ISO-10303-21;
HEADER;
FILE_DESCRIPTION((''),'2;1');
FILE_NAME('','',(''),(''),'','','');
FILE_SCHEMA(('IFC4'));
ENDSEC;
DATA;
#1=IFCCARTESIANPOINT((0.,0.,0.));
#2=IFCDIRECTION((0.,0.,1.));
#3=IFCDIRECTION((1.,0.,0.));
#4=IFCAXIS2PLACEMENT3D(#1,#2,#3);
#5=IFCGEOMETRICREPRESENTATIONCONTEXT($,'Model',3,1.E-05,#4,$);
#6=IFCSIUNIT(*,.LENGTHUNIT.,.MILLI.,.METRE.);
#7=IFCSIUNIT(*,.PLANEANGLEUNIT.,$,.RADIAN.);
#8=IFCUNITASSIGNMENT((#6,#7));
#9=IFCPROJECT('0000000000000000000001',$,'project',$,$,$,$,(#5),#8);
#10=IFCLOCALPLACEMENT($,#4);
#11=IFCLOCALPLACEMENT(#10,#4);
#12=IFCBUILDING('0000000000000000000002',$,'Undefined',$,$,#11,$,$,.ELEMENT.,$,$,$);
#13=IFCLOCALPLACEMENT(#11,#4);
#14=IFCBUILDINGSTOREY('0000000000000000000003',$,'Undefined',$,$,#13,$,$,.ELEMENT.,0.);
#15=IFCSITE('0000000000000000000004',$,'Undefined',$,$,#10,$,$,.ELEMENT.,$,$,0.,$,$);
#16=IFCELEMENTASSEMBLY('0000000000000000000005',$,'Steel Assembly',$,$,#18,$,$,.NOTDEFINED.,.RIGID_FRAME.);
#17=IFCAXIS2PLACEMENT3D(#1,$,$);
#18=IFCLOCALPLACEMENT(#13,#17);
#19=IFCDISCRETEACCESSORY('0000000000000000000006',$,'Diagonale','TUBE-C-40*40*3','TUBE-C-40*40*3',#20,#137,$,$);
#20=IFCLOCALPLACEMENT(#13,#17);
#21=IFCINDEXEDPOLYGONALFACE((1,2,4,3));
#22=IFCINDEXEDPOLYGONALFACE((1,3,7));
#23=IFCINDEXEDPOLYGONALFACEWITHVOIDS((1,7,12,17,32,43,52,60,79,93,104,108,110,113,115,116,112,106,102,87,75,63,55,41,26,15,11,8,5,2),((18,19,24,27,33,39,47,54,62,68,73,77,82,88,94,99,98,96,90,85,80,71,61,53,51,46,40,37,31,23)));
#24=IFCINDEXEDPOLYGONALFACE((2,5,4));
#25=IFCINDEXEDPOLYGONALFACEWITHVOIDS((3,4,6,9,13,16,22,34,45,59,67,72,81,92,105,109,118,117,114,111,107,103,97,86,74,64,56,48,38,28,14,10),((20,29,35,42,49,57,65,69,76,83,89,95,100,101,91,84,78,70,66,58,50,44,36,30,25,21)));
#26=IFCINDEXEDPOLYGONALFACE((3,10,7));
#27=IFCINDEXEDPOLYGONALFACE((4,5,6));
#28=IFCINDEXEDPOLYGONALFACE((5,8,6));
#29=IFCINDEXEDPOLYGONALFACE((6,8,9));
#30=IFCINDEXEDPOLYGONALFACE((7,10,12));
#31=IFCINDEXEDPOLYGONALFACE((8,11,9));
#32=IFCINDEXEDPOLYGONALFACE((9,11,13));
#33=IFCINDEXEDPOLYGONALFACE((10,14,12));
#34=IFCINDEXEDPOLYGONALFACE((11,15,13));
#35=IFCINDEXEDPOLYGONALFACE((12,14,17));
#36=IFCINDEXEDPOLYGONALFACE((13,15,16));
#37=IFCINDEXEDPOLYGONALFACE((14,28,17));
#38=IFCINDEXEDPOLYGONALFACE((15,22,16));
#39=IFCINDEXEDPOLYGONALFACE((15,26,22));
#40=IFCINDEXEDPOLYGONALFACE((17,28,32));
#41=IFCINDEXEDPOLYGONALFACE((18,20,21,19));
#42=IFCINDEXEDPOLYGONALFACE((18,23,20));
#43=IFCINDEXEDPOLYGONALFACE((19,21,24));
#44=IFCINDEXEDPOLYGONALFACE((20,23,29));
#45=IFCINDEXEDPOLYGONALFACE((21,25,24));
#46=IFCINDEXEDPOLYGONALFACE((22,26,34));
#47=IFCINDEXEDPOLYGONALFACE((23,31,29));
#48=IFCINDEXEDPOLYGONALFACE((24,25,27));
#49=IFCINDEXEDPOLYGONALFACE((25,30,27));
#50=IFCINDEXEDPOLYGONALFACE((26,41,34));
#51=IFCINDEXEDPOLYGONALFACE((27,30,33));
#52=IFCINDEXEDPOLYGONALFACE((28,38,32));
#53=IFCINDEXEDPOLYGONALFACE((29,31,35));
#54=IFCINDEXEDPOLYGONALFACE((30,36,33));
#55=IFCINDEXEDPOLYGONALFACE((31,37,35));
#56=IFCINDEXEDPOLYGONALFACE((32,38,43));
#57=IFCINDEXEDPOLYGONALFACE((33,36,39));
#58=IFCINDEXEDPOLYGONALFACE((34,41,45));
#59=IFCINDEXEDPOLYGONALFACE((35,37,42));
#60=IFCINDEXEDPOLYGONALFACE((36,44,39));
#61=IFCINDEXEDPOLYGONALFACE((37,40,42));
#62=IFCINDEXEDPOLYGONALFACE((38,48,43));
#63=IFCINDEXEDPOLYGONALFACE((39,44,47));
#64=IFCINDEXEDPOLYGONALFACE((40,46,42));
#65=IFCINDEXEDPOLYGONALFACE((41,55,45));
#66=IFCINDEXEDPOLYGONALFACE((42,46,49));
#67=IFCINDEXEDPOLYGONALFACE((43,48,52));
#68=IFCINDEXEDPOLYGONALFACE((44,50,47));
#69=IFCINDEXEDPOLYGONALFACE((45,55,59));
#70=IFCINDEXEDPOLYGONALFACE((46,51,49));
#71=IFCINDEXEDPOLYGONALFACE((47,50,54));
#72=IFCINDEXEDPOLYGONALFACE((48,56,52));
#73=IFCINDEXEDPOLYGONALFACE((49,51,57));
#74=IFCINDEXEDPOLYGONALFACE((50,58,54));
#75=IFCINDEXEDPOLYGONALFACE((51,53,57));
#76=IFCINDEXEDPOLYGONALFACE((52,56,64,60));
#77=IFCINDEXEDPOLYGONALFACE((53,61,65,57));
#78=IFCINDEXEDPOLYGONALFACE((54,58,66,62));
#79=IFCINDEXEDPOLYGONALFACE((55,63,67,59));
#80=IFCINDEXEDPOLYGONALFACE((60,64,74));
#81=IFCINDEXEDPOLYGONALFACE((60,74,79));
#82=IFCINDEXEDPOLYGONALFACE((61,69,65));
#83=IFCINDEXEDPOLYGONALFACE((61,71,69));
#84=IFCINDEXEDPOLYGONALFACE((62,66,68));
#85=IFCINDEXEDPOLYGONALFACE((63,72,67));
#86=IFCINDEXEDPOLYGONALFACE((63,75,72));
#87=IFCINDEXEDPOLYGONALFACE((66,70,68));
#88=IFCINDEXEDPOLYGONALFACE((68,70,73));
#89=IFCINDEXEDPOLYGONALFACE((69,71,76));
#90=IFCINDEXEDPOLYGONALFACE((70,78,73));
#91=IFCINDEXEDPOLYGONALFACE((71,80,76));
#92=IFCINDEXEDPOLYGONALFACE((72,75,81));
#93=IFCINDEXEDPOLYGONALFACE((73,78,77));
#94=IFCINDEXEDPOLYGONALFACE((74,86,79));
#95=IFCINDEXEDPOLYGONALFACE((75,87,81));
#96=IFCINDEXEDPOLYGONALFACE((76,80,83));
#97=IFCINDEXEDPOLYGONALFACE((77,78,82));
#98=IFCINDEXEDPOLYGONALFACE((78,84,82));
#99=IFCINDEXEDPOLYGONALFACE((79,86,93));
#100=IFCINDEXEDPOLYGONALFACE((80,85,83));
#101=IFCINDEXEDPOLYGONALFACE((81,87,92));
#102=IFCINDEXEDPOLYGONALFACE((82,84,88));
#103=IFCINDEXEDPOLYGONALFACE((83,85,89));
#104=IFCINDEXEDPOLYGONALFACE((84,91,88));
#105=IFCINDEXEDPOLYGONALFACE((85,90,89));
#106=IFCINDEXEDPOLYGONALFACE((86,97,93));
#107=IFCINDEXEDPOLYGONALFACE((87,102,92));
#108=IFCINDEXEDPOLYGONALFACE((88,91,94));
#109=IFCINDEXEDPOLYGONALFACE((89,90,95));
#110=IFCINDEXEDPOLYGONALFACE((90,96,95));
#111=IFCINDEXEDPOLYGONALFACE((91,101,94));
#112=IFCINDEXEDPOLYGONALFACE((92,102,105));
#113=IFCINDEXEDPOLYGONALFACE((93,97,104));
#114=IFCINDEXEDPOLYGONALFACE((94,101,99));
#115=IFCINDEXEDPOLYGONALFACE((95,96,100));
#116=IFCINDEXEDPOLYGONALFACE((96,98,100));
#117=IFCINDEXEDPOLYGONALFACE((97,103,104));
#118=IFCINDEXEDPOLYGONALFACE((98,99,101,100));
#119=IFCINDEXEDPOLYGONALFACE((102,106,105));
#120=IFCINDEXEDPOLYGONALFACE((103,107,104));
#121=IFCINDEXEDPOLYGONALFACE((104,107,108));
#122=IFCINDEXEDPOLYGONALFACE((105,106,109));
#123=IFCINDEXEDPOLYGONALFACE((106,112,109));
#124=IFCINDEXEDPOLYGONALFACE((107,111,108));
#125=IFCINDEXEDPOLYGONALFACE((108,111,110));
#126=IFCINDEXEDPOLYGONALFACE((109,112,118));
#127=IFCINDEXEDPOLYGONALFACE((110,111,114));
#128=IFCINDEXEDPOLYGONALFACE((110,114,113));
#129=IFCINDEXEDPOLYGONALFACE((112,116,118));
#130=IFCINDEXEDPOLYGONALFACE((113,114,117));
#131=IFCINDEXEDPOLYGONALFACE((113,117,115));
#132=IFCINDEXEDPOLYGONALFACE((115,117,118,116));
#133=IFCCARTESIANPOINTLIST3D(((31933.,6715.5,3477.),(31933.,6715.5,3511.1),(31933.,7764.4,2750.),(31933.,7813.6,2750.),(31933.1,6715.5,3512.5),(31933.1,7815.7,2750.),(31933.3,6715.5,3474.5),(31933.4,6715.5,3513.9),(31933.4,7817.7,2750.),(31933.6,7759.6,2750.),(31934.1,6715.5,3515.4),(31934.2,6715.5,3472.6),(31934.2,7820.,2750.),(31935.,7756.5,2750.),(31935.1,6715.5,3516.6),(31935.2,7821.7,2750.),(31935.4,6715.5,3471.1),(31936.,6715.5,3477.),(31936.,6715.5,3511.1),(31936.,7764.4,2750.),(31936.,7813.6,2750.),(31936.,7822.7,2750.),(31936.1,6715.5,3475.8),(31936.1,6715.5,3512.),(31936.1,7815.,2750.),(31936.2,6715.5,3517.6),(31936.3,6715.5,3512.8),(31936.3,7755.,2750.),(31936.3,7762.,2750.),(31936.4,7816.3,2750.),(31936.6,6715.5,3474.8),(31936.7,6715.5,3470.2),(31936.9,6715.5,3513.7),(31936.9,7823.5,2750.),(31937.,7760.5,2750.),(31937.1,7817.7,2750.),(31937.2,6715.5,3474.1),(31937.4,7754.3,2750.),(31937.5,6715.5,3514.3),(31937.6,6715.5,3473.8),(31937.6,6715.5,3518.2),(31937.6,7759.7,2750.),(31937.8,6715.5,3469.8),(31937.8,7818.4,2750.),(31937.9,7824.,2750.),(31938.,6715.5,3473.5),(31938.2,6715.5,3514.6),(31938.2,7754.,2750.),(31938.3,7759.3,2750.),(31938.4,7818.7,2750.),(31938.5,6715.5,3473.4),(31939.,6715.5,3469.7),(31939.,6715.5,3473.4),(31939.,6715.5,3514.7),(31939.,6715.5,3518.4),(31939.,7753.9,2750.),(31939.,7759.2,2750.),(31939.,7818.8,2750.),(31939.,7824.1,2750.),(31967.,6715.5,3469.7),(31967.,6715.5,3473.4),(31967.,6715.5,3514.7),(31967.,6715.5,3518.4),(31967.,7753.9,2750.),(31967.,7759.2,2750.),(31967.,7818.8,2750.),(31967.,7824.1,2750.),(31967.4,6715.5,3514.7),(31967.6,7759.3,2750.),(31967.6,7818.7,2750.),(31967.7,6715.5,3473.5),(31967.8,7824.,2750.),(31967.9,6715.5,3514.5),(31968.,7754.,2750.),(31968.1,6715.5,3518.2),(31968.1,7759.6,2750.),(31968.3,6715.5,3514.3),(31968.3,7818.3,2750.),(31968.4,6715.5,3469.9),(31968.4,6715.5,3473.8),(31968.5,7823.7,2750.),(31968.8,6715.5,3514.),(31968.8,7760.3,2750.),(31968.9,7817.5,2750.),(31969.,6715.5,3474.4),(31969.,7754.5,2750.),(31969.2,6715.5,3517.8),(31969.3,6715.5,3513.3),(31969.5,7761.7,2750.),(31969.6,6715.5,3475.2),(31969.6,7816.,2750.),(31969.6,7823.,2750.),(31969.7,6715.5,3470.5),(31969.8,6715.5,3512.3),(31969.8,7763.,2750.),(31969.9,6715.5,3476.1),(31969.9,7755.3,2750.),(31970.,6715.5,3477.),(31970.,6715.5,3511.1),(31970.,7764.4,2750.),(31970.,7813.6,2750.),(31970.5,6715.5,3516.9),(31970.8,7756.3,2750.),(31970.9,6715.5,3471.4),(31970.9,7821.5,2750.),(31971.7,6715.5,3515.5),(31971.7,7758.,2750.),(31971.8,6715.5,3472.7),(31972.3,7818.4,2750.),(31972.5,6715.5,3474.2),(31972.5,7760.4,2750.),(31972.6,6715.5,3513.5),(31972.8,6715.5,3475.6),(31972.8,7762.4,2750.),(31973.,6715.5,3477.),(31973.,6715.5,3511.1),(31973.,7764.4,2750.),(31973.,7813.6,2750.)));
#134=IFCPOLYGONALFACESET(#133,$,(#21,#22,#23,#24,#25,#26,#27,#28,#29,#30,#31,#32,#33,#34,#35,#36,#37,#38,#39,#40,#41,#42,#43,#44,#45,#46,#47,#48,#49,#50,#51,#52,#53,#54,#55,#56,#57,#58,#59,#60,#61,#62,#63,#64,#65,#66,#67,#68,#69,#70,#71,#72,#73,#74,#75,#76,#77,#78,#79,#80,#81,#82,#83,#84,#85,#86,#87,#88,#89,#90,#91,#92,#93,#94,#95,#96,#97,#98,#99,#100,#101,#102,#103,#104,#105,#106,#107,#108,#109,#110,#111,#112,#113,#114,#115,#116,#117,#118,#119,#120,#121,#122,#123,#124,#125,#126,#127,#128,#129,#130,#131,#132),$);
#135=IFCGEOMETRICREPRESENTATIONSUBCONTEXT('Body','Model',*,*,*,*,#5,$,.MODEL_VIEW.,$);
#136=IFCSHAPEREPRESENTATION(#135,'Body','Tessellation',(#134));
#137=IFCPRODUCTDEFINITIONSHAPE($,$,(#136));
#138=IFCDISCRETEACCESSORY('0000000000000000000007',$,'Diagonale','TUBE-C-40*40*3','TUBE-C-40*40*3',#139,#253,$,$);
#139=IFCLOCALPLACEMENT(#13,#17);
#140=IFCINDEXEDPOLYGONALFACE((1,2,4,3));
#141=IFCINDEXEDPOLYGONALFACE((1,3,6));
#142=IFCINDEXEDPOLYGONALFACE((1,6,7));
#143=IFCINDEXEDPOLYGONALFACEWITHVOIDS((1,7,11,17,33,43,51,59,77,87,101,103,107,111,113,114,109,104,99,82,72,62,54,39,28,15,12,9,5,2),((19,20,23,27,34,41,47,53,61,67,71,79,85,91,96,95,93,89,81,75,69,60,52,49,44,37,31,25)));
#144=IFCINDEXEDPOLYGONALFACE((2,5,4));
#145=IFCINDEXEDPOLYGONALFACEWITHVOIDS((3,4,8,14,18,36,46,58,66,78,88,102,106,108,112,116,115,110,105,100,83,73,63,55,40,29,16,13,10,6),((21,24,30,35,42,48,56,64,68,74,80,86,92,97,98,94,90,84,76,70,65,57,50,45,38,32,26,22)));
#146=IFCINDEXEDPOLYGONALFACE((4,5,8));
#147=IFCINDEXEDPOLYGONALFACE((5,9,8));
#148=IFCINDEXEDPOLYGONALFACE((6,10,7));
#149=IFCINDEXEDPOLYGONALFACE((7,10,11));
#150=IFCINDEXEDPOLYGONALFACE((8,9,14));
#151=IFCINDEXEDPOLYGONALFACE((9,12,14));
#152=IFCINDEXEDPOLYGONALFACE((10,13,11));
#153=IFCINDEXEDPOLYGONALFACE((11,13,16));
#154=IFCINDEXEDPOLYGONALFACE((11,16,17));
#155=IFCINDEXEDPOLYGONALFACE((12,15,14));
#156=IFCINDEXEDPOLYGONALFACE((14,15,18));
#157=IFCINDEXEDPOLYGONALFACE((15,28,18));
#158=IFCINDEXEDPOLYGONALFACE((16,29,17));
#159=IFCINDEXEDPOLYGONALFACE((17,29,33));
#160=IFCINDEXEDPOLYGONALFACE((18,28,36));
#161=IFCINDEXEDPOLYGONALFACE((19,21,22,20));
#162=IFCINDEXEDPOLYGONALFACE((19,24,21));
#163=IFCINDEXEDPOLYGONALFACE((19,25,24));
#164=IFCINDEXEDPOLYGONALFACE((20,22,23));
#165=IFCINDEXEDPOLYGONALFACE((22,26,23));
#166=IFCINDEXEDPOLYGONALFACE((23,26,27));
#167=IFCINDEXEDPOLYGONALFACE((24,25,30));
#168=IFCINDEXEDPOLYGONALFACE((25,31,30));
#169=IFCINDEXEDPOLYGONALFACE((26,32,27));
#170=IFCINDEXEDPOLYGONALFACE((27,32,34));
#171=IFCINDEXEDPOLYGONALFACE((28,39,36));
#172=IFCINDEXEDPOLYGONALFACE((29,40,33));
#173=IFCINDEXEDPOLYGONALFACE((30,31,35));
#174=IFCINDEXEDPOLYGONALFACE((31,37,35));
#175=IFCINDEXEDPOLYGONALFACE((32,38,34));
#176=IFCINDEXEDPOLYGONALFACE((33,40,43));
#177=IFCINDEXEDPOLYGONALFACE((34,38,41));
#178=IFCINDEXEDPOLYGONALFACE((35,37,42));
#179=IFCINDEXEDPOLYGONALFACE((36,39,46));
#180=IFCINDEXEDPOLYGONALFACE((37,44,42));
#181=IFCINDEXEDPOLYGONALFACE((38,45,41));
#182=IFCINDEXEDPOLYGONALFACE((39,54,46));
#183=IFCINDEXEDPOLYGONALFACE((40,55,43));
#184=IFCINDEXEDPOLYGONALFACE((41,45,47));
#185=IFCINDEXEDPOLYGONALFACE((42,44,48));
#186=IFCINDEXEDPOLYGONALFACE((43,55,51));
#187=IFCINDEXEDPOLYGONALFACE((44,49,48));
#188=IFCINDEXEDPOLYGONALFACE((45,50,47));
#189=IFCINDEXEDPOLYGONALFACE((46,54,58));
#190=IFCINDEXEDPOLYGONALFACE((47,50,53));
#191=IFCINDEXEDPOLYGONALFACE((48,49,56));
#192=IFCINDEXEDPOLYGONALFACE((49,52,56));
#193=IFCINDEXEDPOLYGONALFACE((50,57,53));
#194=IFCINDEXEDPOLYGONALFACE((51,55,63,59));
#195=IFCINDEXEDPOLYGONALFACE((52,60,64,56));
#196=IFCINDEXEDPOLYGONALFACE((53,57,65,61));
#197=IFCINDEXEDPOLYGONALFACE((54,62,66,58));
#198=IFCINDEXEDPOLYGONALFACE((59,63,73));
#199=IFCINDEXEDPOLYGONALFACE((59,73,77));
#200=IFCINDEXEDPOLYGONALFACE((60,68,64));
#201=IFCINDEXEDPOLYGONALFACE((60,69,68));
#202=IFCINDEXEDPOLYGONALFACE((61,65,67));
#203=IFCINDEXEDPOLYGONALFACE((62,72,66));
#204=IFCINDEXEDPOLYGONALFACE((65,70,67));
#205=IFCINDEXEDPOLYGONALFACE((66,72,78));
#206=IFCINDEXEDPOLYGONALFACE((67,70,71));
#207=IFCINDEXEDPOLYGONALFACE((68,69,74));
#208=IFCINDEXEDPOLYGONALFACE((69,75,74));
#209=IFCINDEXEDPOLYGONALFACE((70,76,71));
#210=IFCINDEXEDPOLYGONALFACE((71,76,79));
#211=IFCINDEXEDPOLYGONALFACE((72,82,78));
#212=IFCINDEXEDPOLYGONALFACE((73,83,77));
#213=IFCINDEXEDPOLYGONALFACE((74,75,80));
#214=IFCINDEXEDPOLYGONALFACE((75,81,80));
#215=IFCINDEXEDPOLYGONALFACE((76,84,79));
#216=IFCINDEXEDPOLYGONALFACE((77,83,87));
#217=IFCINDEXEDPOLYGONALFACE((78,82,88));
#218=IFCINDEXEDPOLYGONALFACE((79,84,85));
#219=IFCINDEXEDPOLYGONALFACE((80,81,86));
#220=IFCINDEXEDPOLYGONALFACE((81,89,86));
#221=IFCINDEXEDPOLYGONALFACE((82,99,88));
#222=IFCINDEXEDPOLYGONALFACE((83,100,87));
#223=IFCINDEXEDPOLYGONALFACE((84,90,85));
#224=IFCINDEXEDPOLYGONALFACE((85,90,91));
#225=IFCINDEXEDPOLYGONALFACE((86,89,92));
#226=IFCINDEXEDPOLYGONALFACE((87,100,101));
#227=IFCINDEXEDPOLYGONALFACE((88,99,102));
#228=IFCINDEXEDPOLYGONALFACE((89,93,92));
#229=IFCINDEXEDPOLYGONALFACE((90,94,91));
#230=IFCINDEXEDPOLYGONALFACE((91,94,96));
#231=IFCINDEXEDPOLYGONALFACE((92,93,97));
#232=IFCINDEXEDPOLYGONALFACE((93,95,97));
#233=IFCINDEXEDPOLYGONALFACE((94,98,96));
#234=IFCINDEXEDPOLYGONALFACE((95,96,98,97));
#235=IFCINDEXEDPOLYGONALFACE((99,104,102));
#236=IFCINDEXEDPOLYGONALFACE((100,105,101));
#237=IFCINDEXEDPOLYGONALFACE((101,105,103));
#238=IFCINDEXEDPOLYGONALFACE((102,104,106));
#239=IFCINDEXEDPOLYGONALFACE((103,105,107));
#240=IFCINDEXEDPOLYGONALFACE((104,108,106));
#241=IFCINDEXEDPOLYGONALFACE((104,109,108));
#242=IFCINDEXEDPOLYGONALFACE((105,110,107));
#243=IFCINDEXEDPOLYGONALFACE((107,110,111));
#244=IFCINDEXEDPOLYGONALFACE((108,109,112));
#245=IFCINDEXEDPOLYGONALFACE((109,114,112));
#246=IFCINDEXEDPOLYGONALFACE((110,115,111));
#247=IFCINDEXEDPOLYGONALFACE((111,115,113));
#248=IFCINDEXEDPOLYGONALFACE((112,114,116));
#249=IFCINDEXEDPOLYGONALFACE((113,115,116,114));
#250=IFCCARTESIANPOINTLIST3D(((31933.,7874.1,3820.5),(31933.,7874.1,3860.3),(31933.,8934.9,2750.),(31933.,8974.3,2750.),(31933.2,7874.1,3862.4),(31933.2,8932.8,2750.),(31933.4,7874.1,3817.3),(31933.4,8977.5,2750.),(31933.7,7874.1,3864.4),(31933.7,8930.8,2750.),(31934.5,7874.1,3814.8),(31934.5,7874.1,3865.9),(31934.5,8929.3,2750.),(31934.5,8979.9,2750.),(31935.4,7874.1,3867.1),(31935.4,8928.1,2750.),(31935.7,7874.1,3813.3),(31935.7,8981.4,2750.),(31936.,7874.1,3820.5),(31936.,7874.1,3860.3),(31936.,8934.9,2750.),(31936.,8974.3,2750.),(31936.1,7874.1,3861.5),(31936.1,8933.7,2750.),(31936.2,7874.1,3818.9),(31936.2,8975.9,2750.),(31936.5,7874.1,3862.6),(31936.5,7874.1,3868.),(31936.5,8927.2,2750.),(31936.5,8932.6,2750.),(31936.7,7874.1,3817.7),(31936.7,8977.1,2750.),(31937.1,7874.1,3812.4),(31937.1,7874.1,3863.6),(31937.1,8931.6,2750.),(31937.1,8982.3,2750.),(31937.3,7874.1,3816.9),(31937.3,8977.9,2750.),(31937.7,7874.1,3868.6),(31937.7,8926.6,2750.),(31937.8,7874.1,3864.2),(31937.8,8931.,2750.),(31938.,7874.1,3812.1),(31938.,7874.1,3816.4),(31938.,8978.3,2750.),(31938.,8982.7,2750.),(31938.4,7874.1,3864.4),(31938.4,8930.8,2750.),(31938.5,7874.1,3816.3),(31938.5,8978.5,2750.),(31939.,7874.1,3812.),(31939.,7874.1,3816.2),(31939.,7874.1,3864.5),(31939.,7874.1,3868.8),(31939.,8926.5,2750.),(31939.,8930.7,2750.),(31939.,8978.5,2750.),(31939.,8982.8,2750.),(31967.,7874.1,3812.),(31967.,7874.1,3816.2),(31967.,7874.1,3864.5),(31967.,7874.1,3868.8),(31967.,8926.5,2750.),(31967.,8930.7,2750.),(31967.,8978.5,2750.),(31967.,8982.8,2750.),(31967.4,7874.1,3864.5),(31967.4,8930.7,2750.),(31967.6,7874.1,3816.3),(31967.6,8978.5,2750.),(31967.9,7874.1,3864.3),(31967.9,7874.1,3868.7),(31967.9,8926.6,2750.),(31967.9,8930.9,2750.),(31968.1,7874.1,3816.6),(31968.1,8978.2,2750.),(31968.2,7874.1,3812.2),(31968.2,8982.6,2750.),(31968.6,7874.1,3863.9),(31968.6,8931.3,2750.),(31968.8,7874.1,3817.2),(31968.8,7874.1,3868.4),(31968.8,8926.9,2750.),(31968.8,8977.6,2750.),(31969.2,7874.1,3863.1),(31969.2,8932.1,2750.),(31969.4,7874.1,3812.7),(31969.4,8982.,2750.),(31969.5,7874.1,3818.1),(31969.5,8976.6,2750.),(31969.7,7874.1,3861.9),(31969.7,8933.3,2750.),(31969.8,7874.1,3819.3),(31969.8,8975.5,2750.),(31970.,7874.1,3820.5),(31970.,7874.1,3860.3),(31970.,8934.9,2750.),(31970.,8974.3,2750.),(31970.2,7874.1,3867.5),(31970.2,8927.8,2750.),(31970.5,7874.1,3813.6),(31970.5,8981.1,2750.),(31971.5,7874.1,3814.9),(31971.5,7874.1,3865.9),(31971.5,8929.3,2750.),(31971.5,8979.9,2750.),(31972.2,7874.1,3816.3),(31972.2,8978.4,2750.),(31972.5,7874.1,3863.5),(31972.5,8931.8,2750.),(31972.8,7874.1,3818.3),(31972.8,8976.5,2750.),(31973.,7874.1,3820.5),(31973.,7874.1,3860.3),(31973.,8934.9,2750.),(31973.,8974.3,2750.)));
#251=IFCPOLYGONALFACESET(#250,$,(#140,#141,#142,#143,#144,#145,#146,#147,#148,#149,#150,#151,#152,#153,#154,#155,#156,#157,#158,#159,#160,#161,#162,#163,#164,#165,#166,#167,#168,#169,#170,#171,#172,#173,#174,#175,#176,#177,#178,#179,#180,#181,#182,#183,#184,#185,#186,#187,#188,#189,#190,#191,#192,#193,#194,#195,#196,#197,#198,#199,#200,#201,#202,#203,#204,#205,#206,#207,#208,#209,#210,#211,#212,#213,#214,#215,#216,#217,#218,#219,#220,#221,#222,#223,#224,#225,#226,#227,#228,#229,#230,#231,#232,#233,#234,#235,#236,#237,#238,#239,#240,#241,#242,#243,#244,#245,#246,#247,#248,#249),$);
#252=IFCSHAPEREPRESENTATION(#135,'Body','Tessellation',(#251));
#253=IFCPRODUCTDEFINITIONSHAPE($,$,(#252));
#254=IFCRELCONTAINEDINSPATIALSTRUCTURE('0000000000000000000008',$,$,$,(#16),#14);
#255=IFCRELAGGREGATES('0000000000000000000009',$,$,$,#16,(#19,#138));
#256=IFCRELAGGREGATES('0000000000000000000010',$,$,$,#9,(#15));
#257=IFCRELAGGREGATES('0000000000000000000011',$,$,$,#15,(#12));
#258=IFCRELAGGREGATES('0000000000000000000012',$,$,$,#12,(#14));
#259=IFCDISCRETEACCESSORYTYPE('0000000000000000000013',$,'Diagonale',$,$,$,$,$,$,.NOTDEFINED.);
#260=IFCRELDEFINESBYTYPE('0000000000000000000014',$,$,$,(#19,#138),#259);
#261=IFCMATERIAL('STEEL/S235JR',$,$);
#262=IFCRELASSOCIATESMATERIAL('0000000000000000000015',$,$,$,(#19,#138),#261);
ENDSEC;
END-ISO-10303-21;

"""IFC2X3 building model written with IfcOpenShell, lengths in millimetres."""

from ifc_helpers import new_model, si_unit, frame, origin_with_axes, origin_2d_with_axis, place, context, subcontext, project, spatial, hollow_rectangle, extrude, clip, halfspace, material, type_object, element, aggregate, save


model = new_model("IFC2X3")

# Units and contexts
model_context = context("Model", 3, precision=1e-05, world=origin_with_axes())
body_context = subcontext(model_context, "Body", "Model", "MODEL_VIEW")
ifc_project = project(units=[si_unit("LENGTHUNIT", "METRE", prefix="MILLI"), si_unit("PLANEANGLEUNIT", "RADIAN")], contexts=[model_context])

# Site, building, storey
site_placement = place(None, origin_with_axes())
site = spatial("IfcSite", under=ifc_project, at=site_placement, Name="Undefined", CompositionType="ELEMENT", RefElevation=0.0)
building_placement = place(site_placement, origin_with_axes())
building = spatial("IfcBuilding", under=site, at=building_placement, Name="Undefined", CompositionType="ELEMENT")
storey_placement = place(building_placement, origin_with_axes())
storey = spatial("IfcBuildingStorey", under=building, at=storey_placement, Name="Undefined", CompositionType="ELEMENT", Elevation=0.0)

# Element assembly, discrete accessories
ifc_material_1 = material(Name="STEEL/S235JR")
assembly_1_placement = place(storey_placement, origin_with_axes())
assembly_1 = element("IfcElementAssembly", 1, at=assembly_1_placement, inside=storey, Name="Steel Assembly", AssemblyPlace="NOTDEFINED", PredefinedType="RIGID_FRAME")
discrete_accessory_type_1 = type_object("IfcDiscreteAccessoryType", Name="Diagonale")
discrete_accessory_1_placement = place(assembly_1_placement, frame((31953.0, 7812.7, 2733.6), z_axis=(0.0, 0.569631, 0.821901), x_axis=(0.0, -0.821901, 0.569631)))
discrete_accessory_1 = element("IfcDiscreteAccessory", 2, at=discrete_accessory_1_placement, type_object=discrete_accessory_type_1, material=ifc_material_1, Name="Diagonale", Description="TUBE-C-40*40*3", ObjectType="TUBE-C-40*40*3", context=body_context, shape_type="Clipping", body=[
    clip(clip(extrude(hollow_rectangle(XDim=40.0, YDim=40.0, WallThickness=3.0, InnerFilletRadius=3.0, OuterFilletRadius=6.0, at=origin_2d_with_axis()), frame((1378.2, 0.0, 0.0), z_axis=(-1.0, 0.0, 0.0), x_axis=(0.0, -1.0, 0.0)), (0.0, 0.0, 1.0), 1392.5), halfspace(frame((1298.5, 0.0, -52.7), z_axis=(0.821901, 0.0, -0.569631), x_axis=(0.569631, 0.0, 0.821901)), False)), halfspace(frame((80.9, 0.0, -36.0), z_axis=(0.569631, 0.0, 0.821901), x_axis=(-0.821901, 0.0, 0.569631)), True)),
])
discrete_accessory_2_placement = place(assembly_1_placement, frame((31953.0, 8968.6, 2735.9), z_axis=(0.0, 0.710321, 0.703878), x_axis=(0.0, -0.703878, 0.710321)))
discrete_accessory_2 = element("IfcDiscreteAccessory", 3, at=discrete_accessory_2_placement, type_object=discrete_accessory_type_1, material=ifc_material_1, Name="Diagonale", Description="TUBE-C-40*40*3", ObjectType="TUBE-C-40*40*3", context=body_context, shape_type="Clipping", body=[
    clip(clip(extrude(hollow_rectangle(XDim=40.0, YDim=40.0, WallThickness=3.0, InnerFilletRadius=3.0, OuterFilletRadius=6.0, at=origin_2d_with_axis()), frame((1595.3, 0.0, 0.0), z_axis=(-1.0, 0.0, 0.0), x_axis=(0.0, -1.0, 0.0)), (0.0, 0.0, 1.0), 1615.9), halfspace(frame((1512.1, 0.0, -42.4), z_axis=(0.703878, 0.0, -0.710321), x_axis=(0.710321, 0.0, 0.703878)), False)), halfspace(frame((21.0, 0.0, -1.2), z_axis=(-0.710321, 0.0, -0.703878), x_axis=(0.703878, 0.0, -0.710321)), False)),
])
aggregate(assembly_1, [discrete_accessory_1, discrete_accessory_2])

save(model, "model.ifc")
